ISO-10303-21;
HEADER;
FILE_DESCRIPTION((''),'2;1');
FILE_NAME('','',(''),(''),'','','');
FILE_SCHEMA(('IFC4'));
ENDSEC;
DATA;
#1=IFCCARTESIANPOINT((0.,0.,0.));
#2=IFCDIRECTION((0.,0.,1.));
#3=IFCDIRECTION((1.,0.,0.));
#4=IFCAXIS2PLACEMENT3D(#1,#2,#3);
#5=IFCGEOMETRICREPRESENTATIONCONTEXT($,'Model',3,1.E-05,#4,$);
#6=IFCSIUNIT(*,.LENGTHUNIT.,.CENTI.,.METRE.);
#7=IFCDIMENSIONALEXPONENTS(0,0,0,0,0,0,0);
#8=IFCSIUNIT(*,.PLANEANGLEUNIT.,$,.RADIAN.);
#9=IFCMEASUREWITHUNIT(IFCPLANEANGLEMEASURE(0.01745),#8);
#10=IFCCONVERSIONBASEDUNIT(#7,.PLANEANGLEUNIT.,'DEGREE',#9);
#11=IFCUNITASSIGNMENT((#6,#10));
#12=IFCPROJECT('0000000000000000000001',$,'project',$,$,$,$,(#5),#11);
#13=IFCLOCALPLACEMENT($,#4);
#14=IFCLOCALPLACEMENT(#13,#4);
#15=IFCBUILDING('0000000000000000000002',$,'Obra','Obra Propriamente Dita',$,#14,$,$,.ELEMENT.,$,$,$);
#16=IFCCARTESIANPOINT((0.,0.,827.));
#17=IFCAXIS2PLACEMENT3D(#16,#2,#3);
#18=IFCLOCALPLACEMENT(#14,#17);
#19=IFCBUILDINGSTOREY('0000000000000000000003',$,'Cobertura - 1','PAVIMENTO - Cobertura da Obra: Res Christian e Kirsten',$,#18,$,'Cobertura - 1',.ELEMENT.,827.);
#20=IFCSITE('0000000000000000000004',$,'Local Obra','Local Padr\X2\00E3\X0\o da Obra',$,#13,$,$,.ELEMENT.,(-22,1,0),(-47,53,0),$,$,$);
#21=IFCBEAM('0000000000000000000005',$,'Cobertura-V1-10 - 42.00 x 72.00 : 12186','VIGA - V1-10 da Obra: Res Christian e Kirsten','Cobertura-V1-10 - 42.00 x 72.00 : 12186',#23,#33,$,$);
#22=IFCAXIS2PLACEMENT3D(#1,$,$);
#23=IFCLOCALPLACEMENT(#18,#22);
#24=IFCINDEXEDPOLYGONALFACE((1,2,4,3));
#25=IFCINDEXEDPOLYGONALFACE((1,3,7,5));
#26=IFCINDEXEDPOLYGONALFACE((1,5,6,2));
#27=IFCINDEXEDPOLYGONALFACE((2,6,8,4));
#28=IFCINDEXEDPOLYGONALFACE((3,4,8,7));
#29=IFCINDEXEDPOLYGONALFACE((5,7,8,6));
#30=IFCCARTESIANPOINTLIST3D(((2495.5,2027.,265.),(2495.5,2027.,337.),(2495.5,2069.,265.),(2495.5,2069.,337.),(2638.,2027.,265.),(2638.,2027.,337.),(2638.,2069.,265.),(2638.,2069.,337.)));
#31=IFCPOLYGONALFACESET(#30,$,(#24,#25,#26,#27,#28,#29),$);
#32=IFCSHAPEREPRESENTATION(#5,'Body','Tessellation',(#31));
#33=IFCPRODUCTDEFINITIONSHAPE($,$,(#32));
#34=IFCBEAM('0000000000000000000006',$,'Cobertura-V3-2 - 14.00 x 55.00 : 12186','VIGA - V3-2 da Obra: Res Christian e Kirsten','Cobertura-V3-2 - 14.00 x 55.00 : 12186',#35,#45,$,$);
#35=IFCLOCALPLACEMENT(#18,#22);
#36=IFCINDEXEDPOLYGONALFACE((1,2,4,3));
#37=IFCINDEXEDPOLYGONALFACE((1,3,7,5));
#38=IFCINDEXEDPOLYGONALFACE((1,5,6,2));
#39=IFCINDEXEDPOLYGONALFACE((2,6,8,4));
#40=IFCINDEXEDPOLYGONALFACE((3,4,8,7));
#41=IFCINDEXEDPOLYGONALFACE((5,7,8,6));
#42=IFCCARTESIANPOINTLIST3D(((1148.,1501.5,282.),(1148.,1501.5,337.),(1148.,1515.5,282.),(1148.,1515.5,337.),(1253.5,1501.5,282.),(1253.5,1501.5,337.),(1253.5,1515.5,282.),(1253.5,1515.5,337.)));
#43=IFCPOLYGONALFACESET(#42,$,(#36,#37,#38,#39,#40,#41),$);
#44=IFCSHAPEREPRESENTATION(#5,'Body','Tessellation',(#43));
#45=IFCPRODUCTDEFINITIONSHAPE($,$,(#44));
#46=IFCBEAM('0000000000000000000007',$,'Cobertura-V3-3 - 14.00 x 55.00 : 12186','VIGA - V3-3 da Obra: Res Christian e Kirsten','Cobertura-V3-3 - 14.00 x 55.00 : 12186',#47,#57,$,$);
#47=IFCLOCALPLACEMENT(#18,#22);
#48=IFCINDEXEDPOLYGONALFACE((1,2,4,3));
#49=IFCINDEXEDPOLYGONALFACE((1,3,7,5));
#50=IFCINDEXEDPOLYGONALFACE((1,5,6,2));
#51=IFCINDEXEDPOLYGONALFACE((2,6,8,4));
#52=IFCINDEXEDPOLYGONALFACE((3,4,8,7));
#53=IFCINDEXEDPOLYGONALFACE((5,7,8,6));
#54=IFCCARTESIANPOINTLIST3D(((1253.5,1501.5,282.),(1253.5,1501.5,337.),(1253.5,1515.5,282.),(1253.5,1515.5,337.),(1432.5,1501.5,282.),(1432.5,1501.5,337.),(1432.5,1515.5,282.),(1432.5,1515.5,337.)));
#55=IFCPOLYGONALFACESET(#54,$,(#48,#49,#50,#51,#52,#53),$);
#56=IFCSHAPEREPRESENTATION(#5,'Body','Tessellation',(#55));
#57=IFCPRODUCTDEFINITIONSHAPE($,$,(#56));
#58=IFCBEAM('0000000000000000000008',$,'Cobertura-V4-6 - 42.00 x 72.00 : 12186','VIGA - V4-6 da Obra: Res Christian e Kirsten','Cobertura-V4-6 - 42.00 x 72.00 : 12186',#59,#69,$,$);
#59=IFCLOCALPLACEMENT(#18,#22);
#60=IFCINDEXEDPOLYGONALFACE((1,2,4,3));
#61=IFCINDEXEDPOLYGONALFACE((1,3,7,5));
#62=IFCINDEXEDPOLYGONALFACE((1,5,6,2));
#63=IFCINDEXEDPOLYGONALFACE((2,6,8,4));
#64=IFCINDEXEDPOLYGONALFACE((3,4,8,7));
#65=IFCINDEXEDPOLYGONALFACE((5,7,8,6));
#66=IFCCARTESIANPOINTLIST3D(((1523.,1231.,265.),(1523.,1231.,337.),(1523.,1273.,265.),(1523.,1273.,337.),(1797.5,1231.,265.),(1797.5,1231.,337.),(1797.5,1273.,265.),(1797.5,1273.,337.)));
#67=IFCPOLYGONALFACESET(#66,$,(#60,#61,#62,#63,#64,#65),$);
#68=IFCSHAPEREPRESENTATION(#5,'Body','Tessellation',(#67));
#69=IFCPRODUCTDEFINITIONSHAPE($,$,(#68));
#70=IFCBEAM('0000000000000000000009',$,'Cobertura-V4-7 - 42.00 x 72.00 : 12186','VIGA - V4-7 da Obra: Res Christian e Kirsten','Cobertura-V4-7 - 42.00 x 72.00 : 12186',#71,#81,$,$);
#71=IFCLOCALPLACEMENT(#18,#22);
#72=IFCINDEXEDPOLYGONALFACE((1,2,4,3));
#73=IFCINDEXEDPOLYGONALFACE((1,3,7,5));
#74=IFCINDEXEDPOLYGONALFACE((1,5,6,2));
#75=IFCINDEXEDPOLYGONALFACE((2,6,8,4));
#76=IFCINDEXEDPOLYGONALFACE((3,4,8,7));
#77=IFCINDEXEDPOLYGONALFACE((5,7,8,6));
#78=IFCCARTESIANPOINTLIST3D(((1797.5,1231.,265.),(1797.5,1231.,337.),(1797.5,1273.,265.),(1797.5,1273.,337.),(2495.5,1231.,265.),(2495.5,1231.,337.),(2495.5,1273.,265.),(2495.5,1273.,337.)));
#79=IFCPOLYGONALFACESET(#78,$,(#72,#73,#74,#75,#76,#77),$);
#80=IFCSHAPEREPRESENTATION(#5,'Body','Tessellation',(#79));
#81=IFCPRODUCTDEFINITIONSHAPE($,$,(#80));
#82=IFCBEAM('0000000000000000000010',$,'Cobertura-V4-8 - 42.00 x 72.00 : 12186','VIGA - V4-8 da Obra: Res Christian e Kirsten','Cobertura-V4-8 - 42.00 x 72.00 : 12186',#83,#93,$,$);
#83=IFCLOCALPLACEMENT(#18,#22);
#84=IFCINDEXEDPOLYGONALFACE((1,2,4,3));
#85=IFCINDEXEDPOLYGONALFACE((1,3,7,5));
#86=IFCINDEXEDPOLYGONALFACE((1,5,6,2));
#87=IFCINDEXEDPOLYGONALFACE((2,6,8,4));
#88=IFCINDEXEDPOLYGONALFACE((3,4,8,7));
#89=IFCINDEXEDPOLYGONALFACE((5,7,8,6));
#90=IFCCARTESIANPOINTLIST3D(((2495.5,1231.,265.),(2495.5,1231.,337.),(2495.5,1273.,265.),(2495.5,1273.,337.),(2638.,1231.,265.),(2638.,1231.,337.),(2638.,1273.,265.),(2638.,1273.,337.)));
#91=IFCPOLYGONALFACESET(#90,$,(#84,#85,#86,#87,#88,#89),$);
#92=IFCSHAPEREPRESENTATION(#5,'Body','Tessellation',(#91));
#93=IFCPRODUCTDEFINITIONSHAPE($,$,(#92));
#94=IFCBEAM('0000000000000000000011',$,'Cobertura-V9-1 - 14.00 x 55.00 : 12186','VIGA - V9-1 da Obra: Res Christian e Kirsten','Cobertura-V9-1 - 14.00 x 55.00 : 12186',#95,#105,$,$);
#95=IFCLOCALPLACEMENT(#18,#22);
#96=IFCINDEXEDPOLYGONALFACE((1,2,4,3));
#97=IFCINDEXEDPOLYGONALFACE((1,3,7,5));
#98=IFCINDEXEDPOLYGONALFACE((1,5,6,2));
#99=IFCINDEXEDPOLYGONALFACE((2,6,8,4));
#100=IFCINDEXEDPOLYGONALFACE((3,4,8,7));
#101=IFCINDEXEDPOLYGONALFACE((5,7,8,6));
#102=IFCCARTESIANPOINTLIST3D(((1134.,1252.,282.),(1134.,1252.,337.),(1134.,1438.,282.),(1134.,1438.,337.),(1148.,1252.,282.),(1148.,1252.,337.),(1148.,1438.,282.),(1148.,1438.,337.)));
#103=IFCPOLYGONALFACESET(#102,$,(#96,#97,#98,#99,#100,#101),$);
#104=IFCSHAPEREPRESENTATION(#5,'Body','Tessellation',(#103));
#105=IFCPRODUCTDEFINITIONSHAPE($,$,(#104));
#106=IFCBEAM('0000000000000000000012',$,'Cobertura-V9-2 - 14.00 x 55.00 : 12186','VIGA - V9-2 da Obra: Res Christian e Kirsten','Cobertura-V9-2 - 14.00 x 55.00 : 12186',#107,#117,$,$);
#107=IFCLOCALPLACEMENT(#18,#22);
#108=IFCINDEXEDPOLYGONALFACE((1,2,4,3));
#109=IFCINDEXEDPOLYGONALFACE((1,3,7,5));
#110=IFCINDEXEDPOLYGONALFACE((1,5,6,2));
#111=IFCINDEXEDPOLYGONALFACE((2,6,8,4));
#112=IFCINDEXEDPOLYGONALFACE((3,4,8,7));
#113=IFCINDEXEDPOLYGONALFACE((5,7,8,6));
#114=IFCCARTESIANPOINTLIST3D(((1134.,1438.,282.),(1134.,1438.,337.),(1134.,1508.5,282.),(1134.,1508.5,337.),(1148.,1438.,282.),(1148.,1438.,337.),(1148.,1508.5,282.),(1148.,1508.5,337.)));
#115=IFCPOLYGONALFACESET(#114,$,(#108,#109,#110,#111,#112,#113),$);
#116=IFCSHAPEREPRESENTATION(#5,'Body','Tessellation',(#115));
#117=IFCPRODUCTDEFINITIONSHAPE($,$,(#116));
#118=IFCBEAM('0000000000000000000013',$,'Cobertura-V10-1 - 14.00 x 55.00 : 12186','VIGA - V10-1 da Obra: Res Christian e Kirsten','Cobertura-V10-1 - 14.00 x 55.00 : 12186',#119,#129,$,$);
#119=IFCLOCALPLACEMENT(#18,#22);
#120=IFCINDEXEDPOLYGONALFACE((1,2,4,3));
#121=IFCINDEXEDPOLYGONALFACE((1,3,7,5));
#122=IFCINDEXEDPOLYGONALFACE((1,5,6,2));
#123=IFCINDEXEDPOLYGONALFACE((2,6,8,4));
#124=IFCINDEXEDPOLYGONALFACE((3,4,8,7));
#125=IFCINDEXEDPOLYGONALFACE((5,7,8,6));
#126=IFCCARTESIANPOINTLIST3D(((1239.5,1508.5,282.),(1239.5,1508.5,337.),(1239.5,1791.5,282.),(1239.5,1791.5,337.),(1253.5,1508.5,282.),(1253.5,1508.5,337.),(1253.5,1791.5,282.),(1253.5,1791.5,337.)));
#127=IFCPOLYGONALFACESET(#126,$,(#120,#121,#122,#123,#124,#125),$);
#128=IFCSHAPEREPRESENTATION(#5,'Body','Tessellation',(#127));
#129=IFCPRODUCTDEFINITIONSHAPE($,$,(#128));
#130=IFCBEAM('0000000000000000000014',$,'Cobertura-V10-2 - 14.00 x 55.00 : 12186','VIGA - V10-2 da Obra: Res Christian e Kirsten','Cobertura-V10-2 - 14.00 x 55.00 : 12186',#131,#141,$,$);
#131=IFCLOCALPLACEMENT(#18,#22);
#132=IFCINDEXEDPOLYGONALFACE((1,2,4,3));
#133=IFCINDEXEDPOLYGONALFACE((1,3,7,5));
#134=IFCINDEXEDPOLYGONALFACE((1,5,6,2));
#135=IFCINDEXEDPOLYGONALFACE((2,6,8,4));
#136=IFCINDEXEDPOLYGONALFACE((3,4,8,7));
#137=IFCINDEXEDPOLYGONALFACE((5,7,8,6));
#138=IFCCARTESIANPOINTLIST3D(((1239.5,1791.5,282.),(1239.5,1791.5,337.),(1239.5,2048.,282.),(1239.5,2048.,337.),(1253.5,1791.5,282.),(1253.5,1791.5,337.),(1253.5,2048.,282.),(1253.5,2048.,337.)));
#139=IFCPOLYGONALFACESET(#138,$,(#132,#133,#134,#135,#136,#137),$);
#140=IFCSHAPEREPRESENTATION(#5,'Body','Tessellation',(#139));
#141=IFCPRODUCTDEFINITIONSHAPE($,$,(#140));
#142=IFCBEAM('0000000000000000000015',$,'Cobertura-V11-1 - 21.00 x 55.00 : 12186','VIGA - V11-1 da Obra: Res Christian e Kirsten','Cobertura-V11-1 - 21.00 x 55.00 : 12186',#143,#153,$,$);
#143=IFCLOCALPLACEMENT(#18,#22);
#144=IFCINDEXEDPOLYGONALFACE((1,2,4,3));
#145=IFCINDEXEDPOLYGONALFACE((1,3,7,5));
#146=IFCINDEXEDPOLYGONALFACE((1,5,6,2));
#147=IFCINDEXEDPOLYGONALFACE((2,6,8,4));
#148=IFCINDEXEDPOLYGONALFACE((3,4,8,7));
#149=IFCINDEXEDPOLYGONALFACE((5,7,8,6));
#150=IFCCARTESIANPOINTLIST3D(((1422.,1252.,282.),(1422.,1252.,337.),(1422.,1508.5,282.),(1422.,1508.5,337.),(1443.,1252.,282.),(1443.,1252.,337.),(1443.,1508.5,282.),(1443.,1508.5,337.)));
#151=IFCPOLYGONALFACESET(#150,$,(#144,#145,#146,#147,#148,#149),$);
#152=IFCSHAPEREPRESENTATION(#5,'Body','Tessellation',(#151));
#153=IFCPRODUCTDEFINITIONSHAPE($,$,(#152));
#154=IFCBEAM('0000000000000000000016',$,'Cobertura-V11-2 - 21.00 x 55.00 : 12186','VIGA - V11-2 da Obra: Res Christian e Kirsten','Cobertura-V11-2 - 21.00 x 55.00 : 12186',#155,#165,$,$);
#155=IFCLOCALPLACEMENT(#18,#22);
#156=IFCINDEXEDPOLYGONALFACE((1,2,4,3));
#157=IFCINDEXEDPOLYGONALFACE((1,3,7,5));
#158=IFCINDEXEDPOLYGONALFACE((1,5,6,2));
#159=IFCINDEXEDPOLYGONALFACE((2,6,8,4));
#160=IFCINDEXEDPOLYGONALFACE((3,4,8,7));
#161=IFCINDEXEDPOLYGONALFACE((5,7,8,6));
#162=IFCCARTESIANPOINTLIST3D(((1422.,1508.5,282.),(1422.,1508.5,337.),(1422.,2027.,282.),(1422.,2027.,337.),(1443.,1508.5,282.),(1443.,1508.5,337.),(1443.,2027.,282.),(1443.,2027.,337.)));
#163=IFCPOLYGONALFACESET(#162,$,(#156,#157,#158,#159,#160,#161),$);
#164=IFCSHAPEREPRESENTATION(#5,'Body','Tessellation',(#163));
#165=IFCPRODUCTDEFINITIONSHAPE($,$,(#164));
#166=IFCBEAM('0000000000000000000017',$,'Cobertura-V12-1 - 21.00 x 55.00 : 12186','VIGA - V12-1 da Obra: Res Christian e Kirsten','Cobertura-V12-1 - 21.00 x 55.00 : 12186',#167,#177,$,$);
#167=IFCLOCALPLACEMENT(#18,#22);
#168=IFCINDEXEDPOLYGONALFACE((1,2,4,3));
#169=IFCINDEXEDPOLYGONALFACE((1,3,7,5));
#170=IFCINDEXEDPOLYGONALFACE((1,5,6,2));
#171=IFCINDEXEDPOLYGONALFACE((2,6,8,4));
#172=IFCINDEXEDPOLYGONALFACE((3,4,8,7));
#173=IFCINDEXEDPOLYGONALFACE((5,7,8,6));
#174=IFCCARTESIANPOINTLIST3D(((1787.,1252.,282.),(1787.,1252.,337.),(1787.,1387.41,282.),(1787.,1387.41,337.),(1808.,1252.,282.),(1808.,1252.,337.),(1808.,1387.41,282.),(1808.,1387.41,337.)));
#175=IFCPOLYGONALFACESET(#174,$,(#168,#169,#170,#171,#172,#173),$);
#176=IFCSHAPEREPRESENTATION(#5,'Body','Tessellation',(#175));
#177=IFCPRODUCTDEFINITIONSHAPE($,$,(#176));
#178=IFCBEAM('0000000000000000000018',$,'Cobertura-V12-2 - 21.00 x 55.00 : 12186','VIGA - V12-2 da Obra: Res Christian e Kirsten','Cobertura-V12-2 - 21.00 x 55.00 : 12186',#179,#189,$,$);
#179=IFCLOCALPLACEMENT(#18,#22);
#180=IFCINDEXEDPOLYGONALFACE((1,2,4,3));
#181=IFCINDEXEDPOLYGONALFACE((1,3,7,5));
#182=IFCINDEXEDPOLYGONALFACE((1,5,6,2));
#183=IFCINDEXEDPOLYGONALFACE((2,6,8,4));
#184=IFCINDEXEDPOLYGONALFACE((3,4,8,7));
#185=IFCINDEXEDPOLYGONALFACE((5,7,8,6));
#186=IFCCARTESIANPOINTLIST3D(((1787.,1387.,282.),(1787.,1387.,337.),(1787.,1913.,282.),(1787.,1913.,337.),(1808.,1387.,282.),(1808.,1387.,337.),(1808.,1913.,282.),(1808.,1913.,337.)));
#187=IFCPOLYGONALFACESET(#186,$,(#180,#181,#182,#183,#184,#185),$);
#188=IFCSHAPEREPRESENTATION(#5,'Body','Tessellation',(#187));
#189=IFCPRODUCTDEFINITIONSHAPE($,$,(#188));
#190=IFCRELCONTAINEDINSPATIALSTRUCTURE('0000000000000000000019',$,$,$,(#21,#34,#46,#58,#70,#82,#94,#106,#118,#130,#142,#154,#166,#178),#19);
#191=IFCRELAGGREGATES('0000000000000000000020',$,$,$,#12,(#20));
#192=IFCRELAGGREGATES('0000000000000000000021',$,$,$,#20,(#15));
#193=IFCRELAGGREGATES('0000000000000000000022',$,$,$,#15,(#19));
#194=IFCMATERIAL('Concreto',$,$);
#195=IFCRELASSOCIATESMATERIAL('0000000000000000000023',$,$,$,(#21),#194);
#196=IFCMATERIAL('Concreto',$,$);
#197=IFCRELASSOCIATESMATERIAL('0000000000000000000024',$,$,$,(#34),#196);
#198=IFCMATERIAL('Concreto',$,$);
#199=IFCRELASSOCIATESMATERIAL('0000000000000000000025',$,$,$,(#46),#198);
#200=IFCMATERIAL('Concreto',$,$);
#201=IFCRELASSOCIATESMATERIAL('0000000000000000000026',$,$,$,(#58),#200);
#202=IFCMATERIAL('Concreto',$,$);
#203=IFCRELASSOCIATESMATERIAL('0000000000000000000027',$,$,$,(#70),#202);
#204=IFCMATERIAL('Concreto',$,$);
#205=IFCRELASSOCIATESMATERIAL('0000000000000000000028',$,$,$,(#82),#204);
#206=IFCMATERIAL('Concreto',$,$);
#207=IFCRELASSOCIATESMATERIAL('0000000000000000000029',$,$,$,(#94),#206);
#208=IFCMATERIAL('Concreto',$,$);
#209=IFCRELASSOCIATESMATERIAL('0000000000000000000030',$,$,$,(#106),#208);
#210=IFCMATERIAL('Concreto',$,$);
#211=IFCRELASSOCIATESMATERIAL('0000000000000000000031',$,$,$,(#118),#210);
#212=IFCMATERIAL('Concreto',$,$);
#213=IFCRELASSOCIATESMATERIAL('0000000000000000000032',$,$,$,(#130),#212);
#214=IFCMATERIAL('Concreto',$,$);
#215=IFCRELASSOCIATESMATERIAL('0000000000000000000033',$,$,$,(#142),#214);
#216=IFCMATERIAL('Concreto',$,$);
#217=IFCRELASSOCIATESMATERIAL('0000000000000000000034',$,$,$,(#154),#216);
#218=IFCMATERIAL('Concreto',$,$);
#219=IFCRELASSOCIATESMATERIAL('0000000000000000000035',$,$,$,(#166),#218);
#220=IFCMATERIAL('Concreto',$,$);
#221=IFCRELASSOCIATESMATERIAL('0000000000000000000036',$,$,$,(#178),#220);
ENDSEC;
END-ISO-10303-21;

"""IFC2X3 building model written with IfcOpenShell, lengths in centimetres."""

from ifc_helpers import new_model, entity, si_unit, converted_unit, frame, origin_with_axes, place, context, project, spatial, polyline, outline, extrude, material, element, save


model = new_model("IFC2X3")

# Units and contexts
model_context = context("Model", 3, precision=1e-05, world=origin_with_axes())
ifc_project = project(units=[si_unit("LENGTHUNIT", "METRE", prefix="CENTI"), converted_unit("PLANEANGLEUNIT", "DEGREE", entity("IfcPlaneAngleMeasure", 0.01745), si_unit("PLANEANGLEUNIT", "RADIAN"), dimensions=[0, 0, 0, 0, 0, 0, 0])], contexts=[model_context])

# Site, building, storey
site_placement = place(None, origin_with_axes())
site = spatial("IfcSite", under=ifc_project, at=site_placement, Name="Local Obra", Description="Local Padrão da Obra", CompositionType="ELEMENT", RefLatitude=(-22, 1, 0), RefLongitude=(-47, 53, 0))
building_placement = place(site_placement, origin_with_axes())
building = spatial("IfcBuilding", under=site, at=building_placement, Name="Obra", Description="Obra Propriamente Dita", CompositionType="ELEMENT")
storey_placement = place(building_placement, frame((0.0, 0.0, 827.0), z_axis=(0.0, 0.0, 1.0), x_axis=(1.0, 0.0, 0.0)))
storey = spatial("IfcBuildingStorey", under=building, at=storey_placement, Name="Cobertura - 1", Description="PAVIMENTO - Cobertura da Obra: Res Christian e Kirsten", LongName="Cobertura - 1", CompositionType="ELEMENT", Elevation=827.0)

# Beams
ifc_material_1 = material(Name="Concreto")
beam_1_placement = place(storey_placement, frame((2495.5, 2048.0, 337.0), z_axis=(1.0, 0.0, 0.0), x_axis=(0.0, -1.0, 0.0)))
element("IfcBeam", 1, at=beam_1_placement, inside=storey, material=ifc_material_1, Name="Cobertura-V1-10 - 42.00 x 72.00 : 12186", Description="VIGA - V1-10 da Obra: Res Christian e Kirsten", ObjectType="Cobertura-V1-10 - 42.00 x 72.00 : 12186", context=model_context, shape_type="SweptSolid", body=[
    extrude(outline(polyline([(-21.0, 0.0), (21.0, 0.0), (21.0, 72.0), (-21.0, 72.0), (-21.0, 0.0)])), origin_with_axes(), (0.0, 0.0, 1.0), 142.5),
])
ifc_material_2 = material(Name="Concreto")
beam_2_placement = place(storey_placement, frame((1148.0, 1508.5, 337.0), z_axis=(1.0, 0.0, 0.0), x_axis=(0.0, -1.0, 0.0)))
element("IfcBeam", 2, at=beam_2_placement, inside=storey, material=ifc_material_2, Name="Cobertura-V3-2 - 14.00 x 55.00 : 12186", Description="VIGA - V3-2 da Obra: Res Christian e Kirsten", ObjectType="Cobertura-V3-2 - 14.00 x 55.00 : 12186", context=model_context, shape_type="SweptSolid", body=[
    extrude(outline(polyline([(-7.0, 0.0), (7.0, 0.0), (7.0, 55.0), (-7.0, 55.0), (-7.0, 0.0)])), origin_with_axes(), (0.0, 0.0, 1.0), 105.5),
])
ifc_material_3 = material(Name="Concreto")
beam_3_placement = place(storey_placement, frame((1253.5, 1508.5, 337.0), z_axis=(1.0, 0.0, 0.0), x_axis=(0.0, -1.0, 0.0)))
element("IfcBeam", 3, at=beam_3_placement, inside=storey, material=ifc_material_3, Name="Cobertura-V3-3 - 14.00 x 55.00 : 12186", Description="VIGA - V3-3 da Obra: Res Christian e Kirsten", ObjectType="Cobertura-V3-3 - 14.00 x 55.00 : 12186", context=model_context, shape_type="SweptSolid", body=[
    extrude(outline(polyline([(-7.0, 0.0), (7.0, 0.0), (7.0, 55.0), (-7.0, 55.0), (-7.0, 0.0)])), origin_with_axes(), (0.0, 0.0, 1.0), 179.0),
])
ifc_material_4 = material(Name="Concreto")
beam_4_placement = place(storey_placement, frame((1523.0, 1252.0, 337.0), z_axis=(1.0, 0.0, 0.0), x_axis=(0.0, -1.0, 0.0)))
element("IfcBeam", 4, at=beam_4_placement, inside=storey, material=ifc_material_4, Name="Cobertura-V4-6 - 42.00 x 72.00 : 12186", Description="VIGA - V4-6 da Obra: Res Christian e Kirsten", ObjectType="Cobertura-V4-6 - 42.00 x 72.00 : 12186", context=model_context, shape_type="SweptSolid", body=[
    extrude(outline(polyline([(-21.0, 0.0), (21.0, 0.0), (21.0, 72.0), (-21.0, 72.0), (-21.0, 0.0)])), origin_with_axes(), (0.0, 0.0, 1.0), 274.5),
])
ifc_material_5 = material(Name="Concreto")
beam_5_placement = place(storey_placement, frame((1797.5, 1252.0, 337.0), z_axis=(1.0, 0.0, 0.0), x_axis=(0.0, -1.0, 0.0)))
element("IfcBeam", 5, at=beam_5_placement, inside=storey, material=ifc_material_5, Name="Cobertura-V4-7 - 42.00 x 72.00 : 12186", Description="VIGA - V4-7 da Obra: Res Christian e Kirsten", ObjectType="Cobertura-V4-7 - 42.00 x 72.00 : 12186", context=model_context, shape_type="SweptSolid", body=[
    extrude(outline(polyline([(-21.0, 0.0), (21.0, 0.0), (21.0, 72.0), (-21.0, 72.0), (-21.0, 0.0)])), origin_with_axes(), (0.0, 0.0, 1.0), 698.0),
])
ifc_material_6 = material(Name="Concreto")
beam_6_placement = place(storey_placement, frame((2495.5, 1252.0, 337.0), z_axis=(1.0, 0.0, 0.0), x_axis=(0.0, -1.0, 0.0)))
element("IfcBeam", 6, at=beam_6_placement, inside=storey, material=ifc_material_6, Name="Cobertura-V4-8 - 42.00 x 72.00 : 12186", Description="VIGA - V4-8 da Obra: Res Christian e Kirsten", ObjectType="Cobertura-V4-8 - 42.00 x 72.00 : 12186", context=model_context, shape_type="SweptSolid", body=[
    extrude(outline(polyline([(-21.0, 0.0), (21.0, 0.0), (21.0, 72.0), (-21.0, 72.0), (-21.0, 0.0)])), origin_with_axes(), (0.0, 0.0, 1.0), 142.5),
])
ifc_material_7 = material(Name="Concreto")
beam_7_placement = place(storey_placement, frame((1148.0, 1252.0, 337.0), z_axis=(0.0, 1.0, 0.0), x_axis=(1.0, 0.0, 0.0)))
element("IfcBeam", 7, at=beam_7_placement, inside=storey, material=ifc_material_7, Name="Cobertura-V9-1 - 14.00 x 55.00 : 12186", Description="VIGA - V9-1 da Obra: Res Christian e Kirsten", ObjectType="Cobertura-V9-1 - 14.00 x 55.00 : 12186", context=model_context, shape_type="SweptSolid", body=[
    extrude(outline(polyline([(-14.0, 0.0), (0.0, 0.0), (0.0, 55.0), (-14.0, 55.0), (-14.0, 0.0)])), origin_with_axes(), (0.0, 0.0, 1.0), 186.0),
])
ifc_material_8 = material(Name="Concreto")
beam_8_placement = place(storey_placement, frame((1148.0, 1438.0, 337.0), z_axis=(0.0, 1.0, 0.0), x_axis=(1.0, 0.0, 0.0)))
element("IfcBeam", 8, at=beam_8_placement, inside=storey, material=ifc_material_8, Name="Cobertura-V9-2 - 14.00 x 55.00 : 12186", Description="VIGA - V9-2 da Obra: Res Christian e Kirsten", ObjectType="Cobertura-V9-2 - 14.00 x 55.00 : 12186", context=model_context, shape_type="SweptSolid", body=[
    extrude(outline(polyline([(-14.0, 0.0), (0.0, 0.0), (0.0, 55.0), (-14.0, 55.0), (-14.0, 0.0)])), origin_with_axes(), (0.0, 0.0, 1.0), 70.5),
])
ifc_material_9 = material(Name="Concreto")
beam_9_placement = place(storey_placement, frame((1253.5, 1508.5, 337.0), z_axis=(0.0, 1.0, 0.0), x_axis=(1.0, 0.0, 0.0)))
element("IfcBeam", 9, at=beam_9_placement, inside=storey, material=ifc_material_9, Name="Cobertura-V10-1 - 14.00 x 55.00 : 12186", Description="VIGA - V10-1 da Obra: Res Christian e Kirsten", ObjectType="Cobertura-V10-1 - 14.00 x 55.00 : 12186", context=model_context, shape_type="SweptSolid", body=[
    extrude(outline(polyline([(-14.0, 0.0), (0.0, 0.0), (0.0, 55.0), (-14.0, 55.0), (-14.0, 0.0)])), origin_with_axes(), (0.0, 0.0, 1.0), 283.0),
])
ifc_material_10 = material(Name="Concreto")
beam_10_placement = place(storey_placement, frame((1253.5, 1791.5, 337.0), z_axis=(0.0, 1.0, 0.0), x_axis=(1.0, 0.0, 0.0)))
element("IfcBeam", 10, at=beam_10_placement, inside=storey, material=ifc_material_10, Name="Cobertura-V10-2 - 14.00 x 55.00 : 12186", Description="VIGA - V10-2 da Obra: Res Christian e Kirsten", ObjectType="Cobertura-V10-2 - 14.00 x 55.00 : 12186", context=model_context, shape_type="SweptSolid", body=[
    extrude(outline(polyline([(-14.0, 0.0), (0.0, 0.0), (0.0, 55.0), (-14.0, 55.0), (-14.0, 0.0)])), origin_with_axes(), (0.0, 0.0, 1.0), 256.5),
])
ifc_material_11 = material(Name="Concreto")
beam_11_placement = place(storey_placement, frame((1432.5, 1252.0, 337.0), z_axis=(0.0, 1.0, 0.0), x_axis=(1.0, 0.0, 0.0)))
element("IfcBeam", 11, at=beam_11_placement, inside=storey, material=ifc_material_11, Name="Cobertura-V11-1 - 21.00 x 55.00 : 12186", Description="VIGA - V11-1 da Obra: Res Christian e Kirsten", ObjectType="Cobertura-V11-1 - 21.00 x 55.00 : 12186", context=model_context, shape_type="SweptSolid", body=[
    extrude(outline(polyline([(-10.5, 0.0), (10.5, 0.0), (10.5, 55.0), (-10.5, 55.0), (-10.5, 0.0)])), origin_with_axes(), (0.0, 0.0, 1.0), 256.5),
])
ifc_material_12 = material(Name="Concreto")
beam_12_placement = place(storey_placement, frame((1432.5, 1508.5, 337.0), z_axis=(0.0, 1.0, 0.0), x_axis=(1.0, 0.0, 0.0)))
element("IfcBeam", 12, at=beam_12_placement, inside=storey, material=ifc_material_12, Name="Cobertura-V11-2 - 21.00 x 55.00 : 12186", Description="VIGA - V11-2 da Obra: Res Christian e Kirsten", ObjectType="Cobertura-V11-2 - 21.00 x 55.00 : 12186", context=model_context, shape_type="SweptSolid", body=[
    extrude(outline(polyline([(-10.5, 0.0), (10.5, 0.0), (10.5, 55.0), (-10.5, 55.0), (-10.5, 0.0)])), origin_with_axes(), (0.0, 0.0, 1.0), 518.5),
])
ifc_material_13 = material(Name="Concreto")
beam_13_placement = place(storey_placement, frame((1797.5, 1252.0, 337.0), z_axis=(0.0, 1.0, 0.0), x_axis=(1.0, 0.0, 0.0)))
element("IfcBeam", 13, at=beam_13_placement, inside=storey, material=ifc_material_13, Name="Cobertura-V12-1 - 21.00 x 55.00 : 12186", Description="VIGA - V12-1 da Obra: Res Christian e Kirsten", ObjectType="Cobertura-V12-1 - 21.00 x 55.00 : 12186", context=model_context, shape_type="SweptSolid", body=[
    extrude(outline(polyline([(-10.5, 0.0), (10.5, 0.0), (10.5, 55.0), (-10.5, 55.0), (-10.5, 0.0)])), origin_with_axes(), (0.0, 0.0, 1.0), 135.41),
])
ifc_material_14 = material(Name="Concreto")
beam_14_placement = place(storey_placement, frame((1808.0, 1387.0, 337.0), z_axis=(0.0, 1.0, 0.0), x_axis=(1.0, 0.0, 0.0)))
element("IfcBeam", 14, at=beam_14_placement, inside=storey, material=ifc_material_14, Name="Cobertura-V12-2 - 21.00 x 55.00 : 12186", Description="VIGA - V12-2 da Obra: Res Christian e Kirsten", ObjectType="Cobertura-V12-2 - 21.00 x 55.00 : 12186", context=model_context, shape_type="SweptSolid", body=[
    extrude(outline(polyline([(-21.0, 0.0), (0.0, 0.0), (0.0, 55.0), (-21.0, 55.0), (-21.0, 0.0)])), origin_with_axes(), (0.0, 0.0, 1.0), 526.0),
])

save(model, "model.ifc")
